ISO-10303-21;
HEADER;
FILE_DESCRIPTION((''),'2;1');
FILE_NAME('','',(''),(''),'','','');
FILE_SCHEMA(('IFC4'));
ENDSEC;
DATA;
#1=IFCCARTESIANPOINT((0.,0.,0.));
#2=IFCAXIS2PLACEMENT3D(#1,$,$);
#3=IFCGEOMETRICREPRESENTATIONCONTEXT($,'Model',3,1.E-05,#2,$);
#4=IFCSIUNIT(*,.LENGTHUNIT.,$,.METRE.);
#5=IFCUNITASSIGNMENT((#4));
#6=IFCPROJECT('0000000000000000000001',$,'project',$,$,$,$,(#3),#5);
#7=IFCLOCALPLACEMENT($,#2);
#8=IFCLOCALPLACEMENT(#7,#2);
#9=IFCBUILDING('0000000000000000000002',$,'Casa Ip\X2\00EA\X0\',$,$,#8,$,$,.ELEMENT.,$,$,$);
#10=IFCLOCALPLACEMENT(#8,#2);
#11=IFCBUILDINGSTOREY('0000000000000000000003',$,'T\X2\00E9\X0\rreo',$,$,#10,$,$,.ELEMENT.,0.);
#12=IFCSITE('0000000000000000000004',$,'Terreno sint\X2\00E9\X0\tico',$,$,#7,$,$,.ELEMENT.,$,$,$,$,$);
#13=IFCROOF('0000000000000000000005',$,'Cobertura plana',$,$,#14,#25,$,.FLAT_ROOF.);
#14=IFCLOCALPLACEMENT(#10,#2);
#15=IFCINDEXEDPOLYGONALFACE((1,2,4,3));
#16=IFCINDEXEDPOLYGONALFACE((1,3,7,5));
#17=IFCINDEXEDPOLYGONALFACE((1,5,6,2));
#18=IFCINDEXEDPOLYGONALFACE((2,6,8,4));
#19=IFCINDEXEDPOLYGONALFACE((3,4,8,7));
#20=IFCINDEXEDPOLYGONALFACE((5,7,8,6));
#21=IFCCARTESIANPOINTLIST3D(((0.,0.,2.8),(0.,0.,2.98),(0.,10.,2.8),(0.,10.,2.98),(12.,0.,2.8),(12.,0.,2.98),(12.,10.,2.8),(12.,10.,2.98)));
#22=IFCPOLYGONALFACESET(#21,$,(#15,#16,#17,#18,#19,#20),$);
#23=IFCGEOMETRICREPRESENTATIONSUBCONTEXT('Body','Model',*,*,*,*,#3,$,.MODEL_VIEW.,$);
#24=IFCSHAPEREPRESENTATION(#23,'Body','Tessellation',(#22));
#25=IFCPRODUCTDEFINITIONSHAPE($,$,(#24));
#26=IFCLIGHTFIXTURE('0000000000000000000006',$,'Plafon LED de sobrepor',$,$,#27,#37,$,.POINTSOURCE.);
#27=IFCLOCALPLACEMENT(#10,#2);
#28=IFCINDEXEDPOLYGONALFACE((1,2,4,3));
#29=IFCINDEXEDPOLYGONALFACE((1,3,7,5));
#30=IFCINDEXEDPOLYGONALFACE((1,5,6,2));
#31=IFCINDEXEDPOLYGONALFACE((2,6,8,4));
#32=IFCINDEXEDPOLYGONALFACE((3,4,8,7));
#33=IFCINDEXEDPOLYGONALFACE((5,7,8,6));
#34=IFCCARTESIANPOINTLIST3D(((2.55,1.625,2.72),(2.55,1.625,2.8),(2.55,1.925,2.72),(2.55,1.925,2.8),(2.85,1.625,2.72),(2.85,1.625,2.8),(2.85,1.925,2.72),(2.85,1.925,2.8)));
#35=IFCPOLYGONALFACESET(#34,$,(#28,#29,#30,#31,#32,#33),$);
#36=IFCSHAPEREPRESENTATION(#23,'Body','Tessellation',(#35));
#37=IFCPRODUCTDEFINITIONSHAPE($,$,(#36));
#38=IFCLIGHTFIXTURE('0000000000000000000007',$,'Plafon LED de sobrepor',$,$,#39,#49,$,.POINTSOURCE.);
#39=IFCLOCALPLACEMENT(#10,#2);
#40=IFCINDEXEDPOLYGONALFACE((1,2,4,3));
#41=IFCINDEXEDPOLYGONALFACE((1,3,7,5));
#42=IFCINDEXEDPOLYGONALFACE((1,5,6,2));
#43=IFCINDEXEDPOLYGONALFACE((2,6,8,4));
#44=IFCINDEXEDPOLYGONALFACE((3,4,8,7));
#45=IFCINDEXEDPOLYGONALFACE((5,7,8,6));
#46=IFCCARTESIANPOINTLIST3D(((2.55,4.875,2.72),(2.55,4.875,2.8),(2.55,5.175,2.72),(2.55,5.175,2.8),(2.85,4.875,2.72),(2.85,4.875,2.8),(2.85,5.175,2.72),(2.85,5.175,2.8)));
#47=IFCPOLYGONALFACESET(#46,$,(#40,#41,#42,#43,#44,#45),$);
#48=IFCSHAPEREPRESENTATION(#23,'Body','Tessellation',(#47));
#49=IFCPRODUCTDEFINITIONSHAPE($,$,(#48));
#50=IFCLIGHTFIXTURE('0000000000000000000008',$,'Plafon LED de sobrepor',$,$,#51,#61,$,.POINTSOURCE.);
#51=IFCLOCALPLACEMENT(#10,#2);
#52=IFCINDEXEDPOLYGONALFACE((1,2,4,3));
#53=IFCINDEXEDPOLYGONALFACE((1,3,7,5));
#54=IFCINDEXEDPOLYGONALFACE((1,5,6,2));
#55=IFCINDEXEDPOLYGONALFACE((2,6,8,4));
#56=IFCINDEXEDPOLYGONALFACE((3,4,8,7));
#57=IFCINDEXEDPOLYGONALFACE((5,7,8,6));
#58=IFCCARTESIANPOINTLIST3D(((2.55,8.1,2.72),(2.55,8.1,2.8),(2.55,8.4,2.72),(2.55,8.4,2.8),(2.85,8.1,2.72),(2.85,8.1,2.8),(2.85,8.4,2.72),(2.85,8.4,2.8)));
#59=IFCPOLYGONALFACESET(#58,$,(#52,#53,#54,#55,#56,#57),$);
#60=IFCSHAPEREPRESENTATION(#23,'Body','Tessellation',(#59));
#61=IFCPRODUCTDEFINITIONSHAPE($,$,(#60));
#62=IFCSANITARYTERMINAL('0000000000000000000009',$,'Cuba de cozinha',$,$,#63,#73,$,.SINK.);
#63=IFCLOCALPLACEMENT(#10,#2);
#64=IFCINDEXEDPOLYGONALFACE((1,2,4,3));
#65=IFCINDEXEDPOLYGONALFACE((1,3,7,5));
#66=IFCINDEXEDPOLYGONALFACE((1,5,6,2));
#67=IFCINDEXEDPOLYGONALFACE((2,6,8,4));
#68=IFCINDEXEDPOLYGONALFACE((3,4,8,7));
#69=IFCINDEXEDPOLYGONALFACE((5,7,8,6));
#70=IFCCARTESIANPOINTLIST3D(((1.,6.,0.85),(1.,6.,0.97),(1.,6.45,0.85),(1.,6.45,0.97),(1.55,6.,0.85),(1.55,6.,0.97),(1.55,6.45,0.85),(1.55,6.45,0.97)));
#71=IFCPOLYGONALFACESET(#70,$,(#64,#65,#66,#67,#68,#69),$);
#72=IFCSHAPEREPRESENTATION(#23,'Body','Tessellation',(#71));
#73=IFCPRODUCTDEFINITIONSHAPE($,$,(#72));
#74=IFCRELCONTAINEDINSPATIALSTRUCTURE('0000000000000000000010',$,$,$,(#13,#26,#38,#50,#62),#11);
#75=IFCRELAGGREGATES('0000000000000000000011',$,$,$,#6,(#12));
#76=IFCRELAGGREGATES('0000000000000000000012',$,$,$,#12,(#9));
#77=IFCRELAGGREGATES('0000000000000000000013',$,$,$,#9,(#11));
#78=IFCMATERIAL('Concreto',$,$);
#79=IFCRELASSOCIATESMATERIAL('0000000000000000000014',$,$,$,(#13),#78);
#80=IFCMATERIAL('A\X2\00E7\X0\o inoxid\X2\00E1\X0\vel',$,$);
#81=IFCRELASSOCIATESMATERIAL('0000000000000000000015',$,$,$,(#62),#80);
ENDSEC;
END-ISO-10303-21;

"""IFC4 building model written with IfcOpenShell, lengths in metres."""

from ifc_helpers import new_model, si_unit, frame, frame_2d, origin, place, context, subcontext, project, spatial, rectangle, extrude, material, element, save


model = new_model("IFC4")

# Units and contexts
model_context = context("Model", 3, precision=1e-05, world=origin())
body_context = subcontext(model_context, "Body", "Model", "MODEL_VIEW")
ifc_project = project(units=[si_unit("LENGTHUNIT", "METRE")], contexts=[model_context])

# Site, building, storey
site_placement = place(None, origin())
site = spatial("IfcSite", under=ifc_project, at=site_placement, Name="Terreno sintético", CompositionType="ELEMENT")
building_placement = place(site_placement, origin())
building = spatial("IfcBuilding", under=site, at=building_placement, Name="Casa Ipê", CompositionType="ELEMENT")
storey_placement = place(building_placement, origin())
storey = spatial("IfcBuildingStorey", under=building, at=storey_placement, Name="Térreo", CompositionType="ELEMENT", Elevation=0.0)

# Shared definitions
ifc_material_1 = material(Name="Concreto")

# Roof
roof_placement = place(storey_placement, frame((0.0, 0.0, 2.8)))
element("IfcRoof", 1, at=roof_placement, inside=storey, material=ifc_material_1, Name="Cobertura plana", PredefinedType="FLAT_ROOF", context=body_context, shape_type="SweptSolid", body=[
    extrude(rectangle(XDim=12.0, YDim=10.0, at=frame_2d((6.0, 5.0))), origin(), (0.0, 0.0, 1.0), 0.18),
])

# Light fixtures
for number, where, name in (
    (2, (2.55, 1.625, 2.72), "Plafon LED de sobrepor"),
    (3, (2.55, 4.875, 2.72), "Plafon LED de sobrepor"),
    (4, (2.55, 8.1, 2.72), "Plafon LED de sobrepor"),
):
    element("IfcLightFixture", number, at=place(storey_placement, frame(where)), inside=storey, Name=name, PredefinedType="POINTSOURCE", context=body_context, shape_type="SweptSolid", body=[
        extrude(rectangle(XDim=0.3, YDim=0.3, at=frame_2d((0.15, 0.15))), origin(), (0.0, 0.0, 1.0), 0.08),
    ])

# Sanitary terminal
ifc_material_2 = material(Name="Aço inoxidável")
sanitary_terminal_placement = place(storey_placement, frame((1.0, 6.0, 0.85)))
element("IfcSanitaryTerminal", 5, at=sanitary_terminal_placement, inside=storey, material=ifc_material_2, Name="Cuba de cozinha", PredefinedType="SINK", context=body_context, shape_type="SweptSolid", body=[
    extrude(rectangle(XDim=0.55, YDim=0.45, at=frame_2d((0.275, 0.225))), origin(), (0.0, 0.0, 1.0), 0.12),
])

save(model, "model.ifc")
